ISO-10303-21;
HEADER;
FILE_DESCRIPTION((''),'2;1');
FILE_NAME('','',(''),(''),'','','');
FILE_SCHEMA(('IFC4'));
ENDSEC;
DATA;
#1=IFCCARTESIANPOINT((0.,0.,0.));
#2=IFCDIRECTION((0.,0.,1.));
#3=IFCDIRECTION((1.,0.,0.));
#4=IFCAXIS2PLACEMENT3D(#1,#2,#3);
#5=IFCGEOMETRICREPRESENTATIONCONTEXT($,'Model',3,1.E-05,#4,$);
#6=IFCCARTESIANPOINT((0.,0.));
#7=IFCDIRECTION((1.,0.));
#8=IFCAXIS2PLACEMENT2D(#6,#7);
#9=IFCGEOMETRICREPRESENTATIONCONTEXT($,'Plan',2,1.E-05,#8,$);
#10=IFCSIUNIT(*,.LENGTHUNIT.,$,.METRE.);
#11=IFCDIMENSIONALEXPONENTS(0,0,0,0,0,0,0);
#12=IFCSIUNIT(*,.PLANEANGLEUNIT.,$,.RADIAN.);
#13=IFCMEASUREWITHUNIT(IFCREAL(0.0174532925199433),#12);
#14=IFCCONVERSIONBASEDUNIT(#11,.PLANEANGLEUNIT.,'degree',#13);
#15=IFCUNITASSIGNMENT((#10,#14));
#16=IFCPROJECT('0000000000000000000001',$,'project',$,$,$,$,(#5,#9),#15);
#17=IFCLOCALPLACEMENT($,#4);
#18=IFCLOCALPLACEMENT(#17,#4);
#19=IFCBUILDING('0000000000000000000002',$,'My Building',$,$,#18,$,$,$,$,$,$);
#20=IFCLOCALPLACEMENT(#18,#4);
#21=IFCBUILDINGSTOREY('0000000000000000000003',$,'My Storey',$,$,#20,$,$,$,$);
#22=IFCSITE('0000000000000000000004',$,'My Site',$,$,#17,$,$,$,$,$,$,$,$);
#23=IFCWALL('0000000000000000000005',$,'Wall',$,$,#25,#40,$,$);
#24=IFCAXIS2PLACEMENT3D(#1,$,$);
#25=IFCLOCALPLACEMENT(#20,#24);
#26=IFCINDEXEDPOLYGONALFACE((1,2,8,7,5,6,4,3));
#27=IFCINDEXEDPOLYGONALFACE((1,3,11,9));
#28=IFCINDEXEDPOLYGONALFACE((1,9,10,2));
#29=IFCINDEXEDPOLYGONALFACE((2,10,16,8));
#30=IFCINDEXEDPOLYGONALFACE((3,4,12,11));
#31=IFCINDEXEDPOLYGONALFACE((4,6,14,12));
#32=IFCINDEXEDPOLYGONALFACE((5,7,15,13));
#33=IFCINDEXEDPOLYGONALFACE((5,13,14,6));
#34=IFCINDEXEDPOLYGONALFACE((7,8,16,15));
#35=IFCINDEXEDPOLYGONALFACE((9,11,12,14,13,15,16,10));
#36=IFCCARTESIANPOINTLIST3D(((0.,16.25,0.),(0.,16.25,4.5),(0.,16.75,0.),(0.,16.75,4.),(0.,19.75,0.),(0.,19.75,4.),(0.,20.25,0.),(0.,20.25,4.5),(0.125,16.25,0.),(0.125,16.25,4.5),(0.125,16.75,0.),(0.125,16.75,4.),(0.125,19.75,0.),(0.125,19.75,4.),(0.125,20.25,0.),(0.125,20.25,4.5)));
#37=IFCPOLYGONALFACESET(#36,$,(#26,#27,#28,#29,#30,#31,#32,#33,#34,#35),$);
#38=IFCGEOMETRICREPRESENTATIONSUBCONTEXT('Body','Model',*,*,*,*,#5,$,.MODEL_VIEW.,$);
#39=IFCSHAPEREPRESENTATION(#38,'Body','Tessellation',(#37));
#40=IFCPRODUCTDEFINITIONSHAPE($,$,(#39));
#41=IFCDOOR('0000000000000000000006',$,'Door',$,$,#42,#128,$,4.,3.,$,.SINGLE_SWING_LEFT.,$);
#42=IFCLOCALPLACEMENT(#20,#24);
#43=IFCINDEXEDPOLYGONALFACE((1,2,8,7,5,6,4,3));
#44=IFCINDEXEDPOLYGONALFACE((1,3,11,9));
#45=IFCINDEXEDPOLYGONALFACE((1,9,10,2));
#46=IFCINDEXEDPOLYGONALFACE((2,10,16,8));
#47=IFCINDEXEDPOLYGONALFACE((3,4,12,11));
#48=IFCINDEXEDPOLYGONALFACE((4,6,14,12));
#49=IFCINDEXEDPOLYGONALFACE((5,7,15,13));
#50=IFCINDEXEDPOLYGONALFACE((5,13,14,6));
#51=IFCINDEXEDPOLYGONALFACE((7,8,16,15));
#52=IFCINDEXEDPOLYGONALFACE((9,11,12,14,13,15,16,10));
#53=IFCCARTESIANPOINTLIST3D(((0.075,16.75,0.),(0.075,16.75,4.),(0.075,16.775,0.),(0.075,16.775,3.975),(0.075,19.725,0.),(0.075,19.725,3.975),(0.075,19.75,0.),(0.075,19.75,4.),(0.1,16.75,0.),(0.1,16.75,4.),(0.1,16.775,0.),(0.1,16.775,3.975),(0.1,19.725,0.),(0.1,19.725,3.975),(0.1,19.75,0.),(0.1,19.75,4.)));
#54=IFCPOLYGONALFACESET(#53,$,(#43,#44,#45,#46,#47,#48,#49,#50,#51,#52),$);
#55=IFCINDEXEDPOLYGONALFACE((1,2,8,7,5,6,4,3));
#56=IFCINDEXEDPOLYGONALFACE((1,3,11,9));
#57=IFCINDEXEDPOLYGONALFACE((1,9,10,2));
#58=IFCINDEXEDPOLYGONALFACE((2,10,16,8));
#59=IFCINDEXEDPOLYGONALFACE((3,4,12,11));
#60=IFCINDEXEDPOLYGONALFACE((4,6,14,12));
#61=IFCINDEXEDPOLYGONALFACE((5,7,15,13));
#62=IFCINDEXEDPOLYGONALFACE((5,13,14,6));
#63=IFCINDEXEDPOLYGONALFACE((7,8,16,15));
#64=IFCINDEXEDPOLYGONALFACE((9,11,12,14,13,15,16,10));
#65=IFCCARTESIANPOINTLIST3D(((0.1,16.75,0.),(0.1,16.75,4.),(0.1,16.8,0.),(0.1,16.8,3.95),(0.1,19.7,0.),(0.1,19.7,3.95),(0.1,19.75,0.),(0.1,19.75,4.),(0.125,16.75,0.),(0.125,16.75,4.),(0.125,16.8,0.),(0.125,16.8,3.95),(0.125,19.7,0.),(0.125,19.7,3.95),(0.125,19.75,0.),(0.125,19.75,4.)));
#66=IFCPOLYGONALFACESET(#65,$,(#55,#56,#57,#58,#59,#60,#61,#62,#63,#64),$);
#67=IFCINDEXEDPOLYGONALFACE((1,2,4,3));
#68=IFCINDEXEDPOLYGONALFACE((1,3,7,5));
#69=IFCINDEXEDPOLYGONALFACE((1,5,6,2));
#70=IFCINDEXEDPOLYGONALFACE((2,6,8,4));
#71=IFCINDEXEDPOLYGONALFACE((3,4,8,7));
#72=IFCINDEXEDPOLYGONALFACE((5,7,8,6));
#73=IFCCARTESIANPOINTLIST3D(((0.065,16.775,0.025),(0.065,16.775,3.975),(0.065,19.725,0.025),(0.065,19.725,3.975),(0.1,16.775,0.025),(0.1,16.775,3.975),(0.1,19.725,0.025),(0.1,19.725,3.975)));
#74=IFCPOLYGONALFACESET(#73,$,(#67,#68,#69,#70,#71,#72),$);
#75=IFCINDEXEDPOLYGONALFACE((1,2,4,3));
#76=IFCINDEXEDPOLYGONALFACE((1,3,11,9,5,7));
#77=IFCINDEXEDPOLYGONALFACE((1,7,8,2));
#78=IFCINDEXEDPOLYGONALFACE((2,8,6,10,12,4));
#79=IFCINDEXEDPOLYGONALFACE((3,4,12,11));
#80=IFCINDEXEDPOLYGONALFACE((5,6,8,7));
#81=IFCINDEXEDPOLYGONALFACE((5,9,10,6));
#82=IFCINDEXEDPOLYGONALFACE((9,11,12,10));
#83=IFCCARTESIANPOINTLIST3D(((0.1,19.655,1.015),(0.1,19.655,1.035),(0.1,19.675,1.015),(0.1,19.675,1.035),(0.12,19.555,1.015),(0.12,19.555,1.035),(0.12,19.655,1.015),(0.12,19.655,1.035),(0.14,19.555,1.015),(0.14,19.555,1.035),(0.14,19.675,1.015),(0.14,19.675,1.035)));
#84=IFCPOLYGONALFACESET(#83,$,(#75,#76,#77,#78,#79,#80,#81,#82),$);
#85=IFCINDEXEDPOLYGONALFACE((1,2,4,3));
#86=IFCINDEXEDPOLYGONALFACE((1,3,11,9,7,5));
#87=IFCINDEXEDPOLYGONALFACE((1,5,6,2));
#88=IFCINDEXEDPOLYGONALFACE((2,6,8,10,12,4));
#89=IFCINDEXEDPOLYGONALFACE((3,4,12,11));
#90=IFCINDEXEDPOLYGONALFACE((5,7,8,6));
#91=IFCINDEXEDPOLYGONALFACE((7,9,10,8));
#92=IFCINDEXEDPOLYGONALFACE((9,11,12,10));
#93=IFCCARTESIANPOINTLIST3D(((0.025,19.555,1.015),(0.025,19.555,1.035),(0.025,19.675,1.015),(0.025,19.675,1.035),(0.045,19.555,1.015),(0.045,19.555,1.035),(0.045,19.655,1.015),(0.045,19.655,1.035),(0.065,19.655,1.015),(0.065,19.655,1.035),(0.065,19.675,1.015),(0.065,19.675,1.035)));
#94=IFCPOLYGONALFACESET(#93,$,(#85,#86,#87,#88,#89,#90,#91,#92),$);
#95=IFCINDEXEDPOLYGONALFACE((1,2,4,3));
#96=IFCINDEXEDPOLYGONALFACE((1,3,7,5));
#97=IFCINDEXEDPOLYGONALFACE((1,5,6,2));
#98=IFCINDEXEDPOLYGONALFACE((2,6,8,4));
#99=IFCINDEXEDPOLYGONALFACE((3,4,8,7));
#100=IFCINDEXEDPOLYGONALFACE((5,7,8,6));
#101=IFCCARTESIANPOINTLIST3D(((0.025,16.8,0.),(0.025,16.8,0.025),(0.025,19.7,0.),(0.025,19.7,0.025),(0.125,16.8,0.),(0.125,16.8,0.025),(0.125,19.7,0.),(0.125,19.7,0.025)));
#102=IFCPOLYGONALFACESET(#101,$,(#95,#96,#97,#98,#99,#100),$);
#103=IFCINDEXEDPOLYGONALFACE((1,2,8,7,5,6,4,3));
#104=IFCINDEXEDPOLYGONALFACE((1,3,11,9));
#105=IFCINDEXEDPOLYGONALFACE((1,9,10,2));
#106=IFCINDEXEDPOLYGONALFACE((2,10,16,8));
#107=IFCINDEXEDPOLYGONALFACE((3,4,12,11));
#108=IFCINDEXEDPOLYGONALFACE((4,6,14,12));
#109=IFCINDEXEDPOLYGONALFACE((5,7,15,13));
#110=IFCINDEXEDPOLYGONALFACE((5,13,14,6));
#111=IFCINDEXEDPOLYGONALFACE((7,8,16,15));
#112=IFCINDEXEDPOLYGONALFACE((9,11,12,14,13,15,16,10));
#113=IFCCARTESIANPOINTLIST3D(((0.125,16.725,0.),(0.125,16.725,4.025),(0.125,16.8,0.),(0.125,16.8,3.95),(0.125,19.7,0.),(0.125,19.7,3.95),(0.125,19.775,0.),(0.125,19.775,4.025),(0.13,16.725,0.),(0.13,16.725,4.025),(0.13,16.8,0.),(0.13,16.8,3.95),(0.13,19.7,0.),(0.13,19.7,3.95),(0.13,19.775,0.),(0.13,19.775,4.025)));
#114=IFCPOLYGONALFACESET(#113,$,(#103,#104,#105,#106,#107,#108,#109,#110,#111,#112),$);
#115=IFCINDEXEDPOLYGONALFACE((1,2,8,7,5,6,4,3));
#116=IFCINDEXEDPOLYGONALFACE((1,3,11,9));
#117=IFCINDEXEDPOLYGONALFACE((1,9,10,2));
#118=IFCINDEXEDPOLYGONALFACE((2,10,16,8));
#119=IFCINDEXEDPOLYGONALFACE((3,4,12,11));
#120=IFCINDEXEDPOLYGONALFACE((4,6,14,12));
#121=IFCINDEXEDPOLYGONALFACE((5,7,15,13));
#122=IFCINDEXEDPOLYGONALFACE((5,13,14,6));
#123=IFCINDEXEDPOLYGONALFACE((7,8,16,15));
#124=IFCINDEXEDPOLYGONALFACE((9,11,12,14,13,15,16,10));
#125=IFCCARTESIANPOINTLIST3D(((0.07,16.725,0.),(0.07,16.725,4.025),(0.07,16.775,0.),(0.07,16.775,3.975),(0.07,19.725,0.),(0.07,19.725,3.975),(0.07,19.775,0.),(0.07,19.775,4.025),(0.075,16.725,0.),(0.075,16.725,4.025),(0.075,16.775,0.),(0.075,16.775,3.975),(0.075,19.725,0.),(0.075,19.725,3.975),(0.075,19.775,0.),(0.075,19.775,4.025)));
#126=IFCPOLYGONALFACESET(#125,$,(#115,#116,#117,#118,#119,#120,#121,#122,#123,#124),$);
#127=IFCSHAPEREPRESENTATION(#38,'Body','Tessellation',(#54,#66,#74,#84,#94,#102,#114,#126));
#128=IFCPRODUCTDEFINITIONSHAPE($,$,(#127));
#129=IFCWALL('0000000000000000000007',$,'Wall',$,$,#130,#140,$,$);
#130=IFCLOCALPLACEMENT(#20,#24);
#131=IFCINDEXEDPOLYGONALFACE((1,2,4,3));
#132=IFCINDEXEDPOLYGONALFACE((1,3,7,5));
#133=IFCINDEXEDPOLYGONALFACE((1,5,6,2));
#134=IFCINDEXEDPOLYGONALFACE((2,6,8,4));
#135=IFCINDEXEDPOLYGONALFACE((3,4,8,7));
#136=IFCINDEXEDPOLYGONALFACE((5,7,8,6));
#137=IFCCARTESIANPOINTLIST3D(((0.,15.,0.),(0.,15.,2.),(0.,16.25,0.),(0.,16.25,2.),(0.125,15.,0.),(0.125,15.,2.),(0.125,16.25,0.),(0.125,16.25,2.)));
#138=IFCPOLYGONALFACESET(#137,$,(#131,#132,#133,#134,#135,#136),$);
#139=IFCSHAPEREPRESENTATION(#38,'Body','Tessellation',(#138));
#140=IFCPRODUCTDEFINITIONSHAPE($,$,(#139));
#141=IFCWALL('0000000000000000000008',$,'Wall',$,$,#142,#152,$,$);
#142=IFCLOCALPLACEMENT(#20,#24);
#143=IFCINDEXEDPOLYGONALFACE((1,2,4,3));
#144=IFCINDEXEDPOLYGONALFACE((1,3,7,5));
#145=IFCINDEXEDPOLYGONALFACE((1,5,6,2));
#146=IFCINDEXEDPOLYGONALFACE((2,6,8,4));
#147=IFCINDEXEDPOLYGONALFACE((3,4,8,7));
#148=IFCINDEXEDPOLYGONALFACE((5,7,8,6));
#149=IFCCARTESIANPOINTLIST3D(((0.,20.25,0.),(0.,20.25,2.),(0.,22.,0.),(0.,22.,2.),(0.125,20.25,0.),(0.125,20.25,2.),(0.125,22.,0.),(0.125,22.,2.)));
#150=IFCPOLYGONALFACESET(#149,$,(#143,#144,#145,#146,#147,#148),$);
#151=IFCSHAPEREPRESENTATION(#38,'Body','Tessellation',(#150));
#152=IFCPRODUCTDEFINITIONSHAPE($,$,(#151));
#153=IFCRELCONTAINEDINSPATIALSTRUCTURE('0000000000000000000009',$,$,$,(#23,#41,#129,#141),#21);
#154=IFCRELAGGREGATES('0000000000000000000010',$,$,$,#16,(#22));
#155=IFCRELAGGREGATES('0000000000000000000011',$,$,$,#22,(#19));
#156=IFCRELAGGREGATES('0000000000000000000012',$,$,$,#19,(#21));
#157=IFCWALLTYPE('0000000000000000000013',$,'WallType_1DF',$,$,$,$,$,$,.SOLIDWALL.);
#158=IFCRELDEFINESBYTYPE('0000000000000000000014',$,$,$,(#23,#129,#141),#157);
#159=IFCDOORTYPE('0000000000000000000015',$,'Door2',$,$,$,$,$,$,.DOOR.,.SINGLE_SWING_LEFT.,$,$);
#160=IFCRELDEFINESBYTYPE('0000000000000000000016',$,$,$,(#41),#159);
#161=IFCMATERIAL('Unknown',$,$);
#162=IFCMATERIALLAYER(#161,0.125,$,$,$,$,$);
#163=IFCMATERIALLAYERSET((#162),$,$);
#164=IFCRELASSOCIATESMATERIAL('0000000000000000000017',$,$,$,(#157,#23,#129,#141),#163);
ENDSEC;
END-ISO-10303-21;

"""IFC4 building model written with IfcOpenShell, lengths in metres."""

from ifc_helpers import new_model, entity, si_unit, converted_unit, frame, origin_with_axes, origin_2d_with_axis, place, context, subcontext, project, spatial, line, indexed_curve, outline, extrude, shape, source, transform, mapped, material, layer, layer_set, layer_usage, type_object, type_shapes, element, fill, save


model = new_model("IFC4")

# Units and contexts
model_context = context("Model", 3, precision=1e-05, world=origin_with_axes())
plan_context = context("Plan", 2, precision=1e-05, world=origin_2d_with_axis())
body_context_1 = subcontext(model_context, "Body", "Model", "MODEL_VIEW")
body_context_2 = subcontext(plan_context, "Body", "Plan", "PLAN_VIEW")
ifc_project = project(units=[si_unit("LENGTHUNIT", "METRE"), converted_unit("PLANEANGLEUNIT", "degree", entity("IfcReal", 0.0174532925199433), si_unit("PLANEANGLEUNIT", "RADIAN"), dimensions=[0, 0, 0, 0, 0, 0, 0])], contexts=[model_context, plan_context])

# Site, building, storey
site_placement = place(None, origin_with_axes())
site = spatial("IfcSite", under=ifc_project, at=site_placement, Name="My Site")
building_placement = place(site_placement, origin_with_axes())
building = spatial("IfcBuilding", under=site, at=building_placement, Name="My Building")
storey_placement = place(building_placement, origin_with_axes())
storey = spatial("IfcBuildingStorey", under=building, at=storey_placement, Name="My Storey")

# Wall, opening, door
ifc_material = material(Name="Unknown")
ifc_layer_1 = layer(ifc_material, 0.125)
ifc_layer_set_1 = layer_set([ifc_layer_1])
ifc_layer_usage_1 = layer_usage(ifc_layer_set_1, "AXIS2", "POSITIVE", 0.0)
wall_type_1 = type_object("IfcWallType", Name="WallType_1DF", PredefinedType="SOLIDWALL", material=ifc_layer_set_1)
wall_1_placement = place(storey_placement, frame((0.125, 16.25, 0.0), z_axis=(0.0, 0.0, 1.0), x_axis=(0.0, 1.0, 0.0)))
wall_1 = element("IfcWall", 1, at=wall_1_placement, inside=storey, type_object=wall_type_1, material=ifc_layer_usage_1, Name="Wall", context=body_context_1, shape_type="SweptSolid", body=[
    extrude(outline(indexed_curve([(0.0, 0.0), (0.0, 0.125), (4.0, 0.125), (4.0, 0.0), (0.0, 0.0)], self_intersect=False)), origin_with_axes(), (0.0, 0.0, 1.0), 4.5),
])
shared_shape_1 = source(origin_with_axes(), body_context_1, "Body", "SweptSolid", [
    extrude(outline(indexed_curve([(0.0, 0.0), (3.0, 0.0), (3.0, 4.0), (0.0, 4.0)], segments=[line(1, 2, 3, 4, 1)])), frame((0.0, -0.1, 0.0), z_axis=(0.0, -1.0, 0.0), x_axis=(1.0, 0.0, 0.0)), (0.0, 0.0, -1.0), 0.45),
])
opening_1_placement = place(wall_1_placement, frame((0.5, 0.0, 0.0), z_axis=(0.0, 0.0, 1.0), x_axis=(1.0, 0.0, 0.0)))
opening_1 = element("IfcOpeningElement", 2, at=opening_1_placement, cuts=wall_1, PredefinedType="OPENING", context=body_context_1, shape_type="MappedRepresentation", body=[
    mapped(shared_shape_1, transform((0.0, 0.0, 0.0), x_axis=(1.0, 0.0, 0.0), y_axis=(0.0, 1.0, 0.0), z_axis=(0.0, 0.0, 1.0), scale=1.0)),
])
door_type_1 = type_object("IfcDoorType", Name="Door2", OperationType="SINGLE_SWING_LEFT", PredefinedType="DOOR")
shared_shape_2 = source(origin_with_axes(), body_context_1, "Body", "SweptSolid", [
    extrude(outline(indexed_curve([(0.0, 0.0), (0.0, 4.0), (3.0, 4.0), (3.0, 0.0), (2.975, 0.0), (2.975, 3.975), (0.025, 3.975), (0.025, 0.0)], segments=[line(1, 2, 3, 4, 5, 6, 7, 8, 1)])), frame((0.0, 0.025, 0.0), z_axis=(0.0, -1.0, 0.0), x_axis=(1.0, 0.0, 0.0)), (0.0, 0.0, -1.0), 0.025),
    extrude(outline(indexed_curve([(0.0, 0.0), (0.0, 4.0), (3.0, 4.0), (3.0, 0.0), (2.95, 0.0), (2.95, 3.95), (0.05, 3.95), (0.05, 0.0)], segments=[line(1, 2, 3, 4, 5, 6, 7, 8, 1)])), frame((0.0, 0.0, 0.0), z_axis=(0.0, -1.0, 0.0), x_axis=(1.0, 0.0, 0.0)), (0.0, 0.0, -1.0), 0.025),
    extrude(outline(indexed_curve([(0.0, 0.0), (2.95, 0.0), (2.95, 0.035), (0.0, 0.035)], segments=[line(1, 2, 3, 4, 1)])), frame((0.025, 0.025, 0.025), z_axis=(0.0, 0.0, 1.0), x_axis=(1.0, 0.0, 0.0)), (0.0, 0.0, 1.0), 3.95),
    extrude(outline(indexed_curve([(0.0, 0.0), (0.0, -0.04), (-0.12, -0.04), (-0.12, -0.02), (-0.02, -0.02), (-0.02, 0.0)], segments=[line(1, 2, 3, 4, 5, 6, 1)])), frame((2.925, 0.025, 1.015), z_axis=(0.0, 0.0, 1.0), x_axis=(1.0, 0.0, 0.0)), (0.0, 0.0, 1.0), 0.02),
    extrude(outline(indexed_curve([(0.0, 0.0), (0.0, 0.04), (-0.12, 0.04), (-0.12, 0.02), (-0.02, 0.02), (-0.02, 0.0)], segments=[line(1, 2, 3, 4, 5, 6, 1)])), frame((2.925, 0.06, 1.015), z_axis=(0.0, 0.0, 1.0), x_axis=(1.0, 0.0, 0.0)), (0.0, 0.0, 1.0), 0.02),
    extrude(outline(indexed_curve([(0.0, 0.0), (2.9, 0.0), (2.9, 0.1), (0.0, 0.1)], segments=[line(1, 2, 3, 4, 1)])), frame((0.05, 0.0, 0.0), z_axis=(0.0, 0.0, 1.0), x_axis=(1.0, 0.0, 0.0)), (0.0, 0.0, 1.0), 0.025),
    extrude(outline(indexed_curve([(0.0, 0.0), (0.0, 4.025), (3.05, 4.025), (3.05, 0.0), (2.975, 0.0), (2.975, 3.95), (0.075, 3.95), (0.075, 0.0)], segments=[line(1, 2, 3, 4, 5, 6, 7, 8, 1)])), frame((-0.025, -0.005, 0.0), z_axis=(0.0, -1.0, 0.0), x_axis=(1.0, 0.0, 0.0)), (0.0, 0.0, -1.0), 0.005),
    extrude(outline(indexed_curve([(0.0, 0.0), (0.0, 4.025), (3.05, 4.025), (3.05, 0.0), (3.0, 0.0), (3.0, 3.975), (0.05, 3.975), (0.05, 0.0)], segments=[line(1, 2, 3, 4, 5, 6, 7, 8, 1)])), frame((-0.025, 0.05, 0.0), z_axis=(0.0, -1.0, 0.0), x_axis=(1.0, 0.0, 0.0)), (0.0, 0.0, -1.0), 0.005),
])
shared_shape_3 = source(origin_with_axes(), body_context_2, "Body", "Curve2D", [
    entity("IfcIndexedPolyCurve", entity("IfcCartesianPointList2D", [[0.0, 0.0], [0.0, 0.05], [0.025, 0.05], [0.025, 0.025], [0.05, 0.025], [0.05, 0.0]]), [entity("IfcLineIndex", [1, 2, 3, 4, 5, 6, 1])]),
    entity("IfcIndexedPolyCurve", entity("IfcCartesianPointList2D", [[3.0, 0.0], [3.0, 0.05], [2.975, 0.05], [2.975, 0.025], [2.95, 0.025], [2.95, 0.0]]), [entity("IfcLineIndex", [1, 2, 3, 4, 5, 6, 1])]),
    entity("IfcTrimmedCurve", entity("IfcEllipse", entity("IfcAxis2Placement2D", entity("IfcCartesianPoint", [0.06, 0.05]), entity("IfcDirection", [1.0, 0.0])), 2.915, 2.95), [entity("IfcCartesianPoint", [2.975, 0.05])], [entity("IfcCartesianPoint", [0.06, 3.0])], True, "CARTESIAN"),
    entity("IfcIndexedPolyCurve", entity("IfcCartesianPointList2D", [[0.025, 0.05], [0.06, 0.05], [0.06, 3.0], [0.025, 3.0]]), [entity("IfcLineIndex", [1, 2, 3, 4, 1])]),
])
type_shapes(door_type_1, [shared_shape_2, shared_shape_3])
door_1_placement = place(opening_1_placement, frame((0.0, 0.0, 0.0), z_axis=(0.0, 0.0, 1.0), x_axis=(1.0, 0.0, 0.0)))
door_1 = element("IfcDoor", 3, at=door_1_placement, inside=storey, type_object=door_type_1, Name="Door", OperationType="SINGLE_SWING_LEFT", OverallHeight=4.0, OverallWidth=3.0, shapes=[
    shape(body_context_1, "Body", "MappedRepresentation", [mapped(shared_shape_2, transform((0.0, 0.0, 0.0), x_axis=(1.0, 0.0, 0.0), y_axis=(0.0, 1.0, 0.0), z_axis=(0.0, 0.0, 1.0), scale=1.0))]),
    shape(body_context_2, "Body", "MappedRepresentation", [mapped(shared_shape_3, transform((0.0, 0.0, 0.0), x_axis=(1.0, 0.0, 0.0), y_axis=(0.0, 1.0, 0.0), z_axis=(0.0, 0.0, 1.0), scale=1.0))]),
])
fill(opening_1, door_1)

# Walls
ifc_layer_usage_2 = layer_usage(ifc_layer_set_1, "AXIS2", "POSITIVE", 0.0)
wall_2_placement = place(storey_placement, frame((0.125, 15.0, 0.0), z_axis=(0.0, 0.0, 1.0), x_axis=(0.0, 1.0, 0.0)))
element("IfcWall", 4, at=wall_2_placement, inside=storey, type_object=wall_type_1, material=ifc_layer_usage_2, Name="Wall", context=body_context_1, shape_type="SweptSolid", body=[
    extrude(outline(indexed_curve([(0.0, 0.0), (0.0, 0.125), (1.25, 0.125), (1.25, 0.0), (0.0, 0.0)], self_intersect=False)), origin_with_axes(), (0.0, 0.0, 1.0), 2.0),
])
ifc_layer_usage_3 = layer_usage(ifc_layer_set_1, "AXIS2", "POSITIVE", 0.0)
wall_3_placement = place(storey_placement, frame((0.125, 20.25, 0.0), z_axis=(0.0, 0.0, 1.0), x_axis=(0.0, 1.0, 0.0)))
element("IfcWall", 5, at=wall_3_placement, inside=storey, type_object=wall_type_1, material=ifc_layer_usage_3, Name="Wall", context=body_context_1, shape_type="SweptSolid", body=[
    extrude(outline(indexed_curve([(0.0, 0.0), (0.0, 0.125), (1.75, 0.125), (1.75, 0.0), (0.0, 0.0)], self_intersect=False)), origin_with_axes(), (0.0, 0.0, 1.0), 2.0),
])

save(model, "model.ifc")
